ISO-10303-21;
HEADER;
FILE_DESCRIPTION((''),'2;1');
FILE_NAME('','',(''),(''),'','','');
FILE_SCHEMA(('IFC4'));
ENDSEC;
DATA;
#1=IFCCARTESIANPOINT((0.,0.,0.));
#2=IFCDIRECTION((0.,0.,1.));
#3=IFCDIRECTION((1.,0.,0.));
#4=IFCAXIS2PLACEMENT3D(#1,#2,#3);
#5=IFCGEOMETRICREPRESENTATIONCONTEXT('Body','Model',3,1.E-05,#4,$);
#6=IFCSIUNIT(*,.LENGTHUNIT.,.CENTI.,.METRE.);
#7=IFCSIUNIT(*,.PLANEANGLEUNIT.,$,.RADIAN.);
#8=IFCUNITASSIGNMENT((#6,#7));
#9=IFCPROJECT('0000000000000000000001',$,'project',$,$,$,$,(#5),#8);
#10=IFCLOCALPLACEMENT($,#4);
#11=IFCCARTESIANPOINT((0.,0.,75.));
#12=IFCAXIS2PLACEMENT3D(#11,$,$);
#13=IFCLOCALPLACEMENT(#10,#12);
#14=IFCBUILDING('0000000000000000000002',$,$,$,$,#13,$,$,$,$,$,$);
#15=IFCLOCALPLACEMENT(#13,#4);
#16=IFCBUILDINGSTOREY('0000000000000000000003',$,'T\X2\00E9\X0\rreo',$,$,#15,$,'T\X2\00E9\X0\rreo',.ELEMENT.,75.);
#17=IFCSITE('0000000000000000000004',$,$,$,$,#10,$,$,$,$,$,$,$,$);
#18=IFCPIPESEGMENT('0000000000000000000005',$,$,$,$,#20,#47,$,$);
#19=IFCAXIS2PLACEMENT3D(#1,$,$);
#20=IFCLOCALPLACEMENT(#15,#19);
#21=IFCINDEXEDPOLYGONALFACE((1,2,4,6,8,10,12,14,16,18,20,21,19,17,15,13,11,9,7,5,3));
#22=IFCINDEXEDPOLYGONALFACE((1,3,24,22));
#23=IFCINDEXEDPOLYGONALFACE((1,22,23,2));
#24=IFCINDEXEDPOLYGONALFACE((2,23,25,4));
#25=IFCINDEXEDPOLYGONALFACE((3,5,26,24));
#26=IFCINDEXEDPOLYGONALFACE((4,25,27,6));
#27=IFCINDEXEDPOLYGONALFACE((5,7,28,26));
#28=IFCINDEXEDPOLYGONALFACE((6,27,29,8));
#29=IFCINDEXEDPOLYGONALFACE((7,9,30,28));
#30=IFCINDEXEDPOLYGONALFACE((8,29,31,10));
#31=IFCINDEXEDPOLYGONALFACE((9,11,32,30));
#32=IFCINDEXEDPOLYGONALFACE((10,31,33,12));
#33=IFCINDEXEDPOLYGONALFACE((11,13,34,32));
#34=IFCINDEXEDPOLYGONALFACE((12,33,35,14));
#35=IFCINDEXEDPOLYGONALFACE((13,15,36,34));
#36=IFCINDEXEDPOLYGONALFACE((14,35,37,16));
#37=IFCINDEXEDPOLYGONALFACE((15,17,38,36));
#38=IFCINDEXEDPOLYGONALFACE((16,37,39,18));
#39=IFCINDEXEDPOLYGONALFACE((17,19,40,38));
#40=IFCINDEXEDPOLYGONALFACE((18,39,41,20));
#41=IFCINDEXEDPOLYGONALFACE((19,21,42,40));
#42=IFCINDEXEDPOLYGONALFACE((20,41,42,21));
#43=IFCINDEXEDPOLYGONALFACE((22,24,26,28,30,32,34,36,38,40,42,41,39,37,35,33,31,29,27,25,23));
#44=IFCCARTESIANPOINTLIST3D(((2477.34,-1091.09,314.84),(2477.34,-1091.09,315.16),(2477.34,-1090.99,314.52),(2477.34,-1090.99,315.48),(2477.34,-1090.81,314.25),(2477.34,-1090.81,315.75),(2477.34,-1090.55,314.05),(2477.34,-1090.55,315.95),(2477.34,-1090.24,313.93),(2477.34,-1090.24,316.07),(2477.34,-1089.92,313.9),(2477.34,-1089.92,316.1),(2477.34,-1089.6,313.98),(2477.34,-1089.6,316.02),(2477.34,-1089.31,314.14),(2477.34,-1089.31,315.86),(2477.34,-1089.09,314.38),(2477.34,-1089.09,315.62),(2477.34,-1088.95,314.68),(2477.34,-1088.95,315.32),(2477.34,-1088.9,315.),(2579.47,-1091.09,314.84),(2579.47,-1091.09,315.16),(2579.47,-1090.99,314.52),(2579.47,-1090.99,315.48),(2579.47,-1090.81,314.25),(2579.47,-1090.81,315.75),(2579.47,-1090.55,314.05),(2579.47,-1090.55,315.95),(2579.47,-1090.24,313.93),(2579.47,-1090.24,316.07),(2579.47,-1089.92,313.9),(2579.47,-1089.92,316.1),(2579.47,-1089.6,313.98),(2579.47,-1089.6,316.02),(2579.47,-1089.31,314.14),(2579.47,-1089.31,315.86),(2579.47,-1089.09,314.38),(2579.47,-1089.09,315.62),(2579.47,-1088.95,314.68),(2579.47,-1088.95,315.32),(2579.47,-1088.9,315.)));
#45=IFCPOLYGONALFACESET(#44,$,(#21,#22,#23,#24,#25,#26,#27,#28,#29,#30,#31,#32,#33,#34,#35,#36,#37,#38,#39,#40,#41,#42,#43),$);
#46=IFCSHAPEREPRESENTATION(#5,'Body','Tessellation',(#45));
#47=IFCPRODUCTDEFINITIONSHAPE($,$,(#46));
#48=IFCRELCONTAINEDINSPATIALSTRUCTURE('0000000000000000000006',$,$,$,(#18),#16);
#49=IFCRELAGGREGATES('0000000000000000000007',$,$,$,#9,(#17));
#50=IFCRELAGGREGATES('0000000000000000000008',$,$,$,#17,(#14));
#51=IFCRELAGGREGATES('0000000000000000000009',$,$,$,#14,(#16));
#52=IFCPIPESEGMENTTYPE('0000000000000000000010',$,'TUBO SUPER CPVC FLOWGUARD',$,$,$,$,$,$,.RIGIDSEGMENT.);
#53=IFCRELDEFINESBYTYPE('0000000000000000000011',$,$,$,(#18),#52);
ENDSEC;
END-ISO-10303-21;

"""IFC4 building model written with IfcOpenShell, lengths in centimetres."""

from ifc_helpers import new_model, si_unit, frame, origin_with_axes, origin_2d_with_axis, place, context, project, spatial, circle, extrude, type_object, element, save


model = new_model("IFC4")

# Units and contexts
model_context = context("Model", 3, precision=1e-05, world=origin_with_axes(), identifier="Body")
ifc_project = project(units=[si_unit("LENGTHUNIT", "METRE", prefix="CENTI"), si_unit("PLANEANGLEUNIT", "RADIAN")], contexts=[model_context])

# Site, building, storey
site_placement = place(None, origin_with_axes())
site = spatial("IfcSite", under=ifc_project, at=site_placement)
building_placement = place(site_placement, frame((0.0, 0.0, 75.0)))
building = spatial("IfcBuilding", under=site, at=building_placement)
storey_placement = place(building_placement, origin_with_axes())
storey = spatial("IfcBuildingStorey", under=building, at=storey_placement, Name="Térreo", LongName="Térreo", CompositionType="ELEMENT", Elevation=75.0)

# Pipe segment
pipe_segment_type_1 = type_object("IfcPipeSegmentType", Name="TUBO SUPER CPVC FLOWGUARD", PredefinedType="RIGIDSEGMENT")
pipe_segment_1_placement = place(storey_placement, frame((2528.41, -1090.0, 316.1), z_axis=(0.0, 0.0, 1.0), x_axis=(1.0, 0.0, 0.0)))
element("IfcPipeSegment", 1, at=pipe_segment_1_placement, inside=storey, type_object=pipe_segment_type_1, context=model_context, shape_type="SolidModel", body=[
    extrude(circle(Radius=1.1, at=origin_2d_with_axis()), frame((-51.07, 0.0, -1.1), z_axis=(1.0, 0.0, 0.0), x_axis=(0.0, 1.0, 0.0)), (0.0, 0.0, 1.0), 102.14),
])

save(model, "model.ifc")
